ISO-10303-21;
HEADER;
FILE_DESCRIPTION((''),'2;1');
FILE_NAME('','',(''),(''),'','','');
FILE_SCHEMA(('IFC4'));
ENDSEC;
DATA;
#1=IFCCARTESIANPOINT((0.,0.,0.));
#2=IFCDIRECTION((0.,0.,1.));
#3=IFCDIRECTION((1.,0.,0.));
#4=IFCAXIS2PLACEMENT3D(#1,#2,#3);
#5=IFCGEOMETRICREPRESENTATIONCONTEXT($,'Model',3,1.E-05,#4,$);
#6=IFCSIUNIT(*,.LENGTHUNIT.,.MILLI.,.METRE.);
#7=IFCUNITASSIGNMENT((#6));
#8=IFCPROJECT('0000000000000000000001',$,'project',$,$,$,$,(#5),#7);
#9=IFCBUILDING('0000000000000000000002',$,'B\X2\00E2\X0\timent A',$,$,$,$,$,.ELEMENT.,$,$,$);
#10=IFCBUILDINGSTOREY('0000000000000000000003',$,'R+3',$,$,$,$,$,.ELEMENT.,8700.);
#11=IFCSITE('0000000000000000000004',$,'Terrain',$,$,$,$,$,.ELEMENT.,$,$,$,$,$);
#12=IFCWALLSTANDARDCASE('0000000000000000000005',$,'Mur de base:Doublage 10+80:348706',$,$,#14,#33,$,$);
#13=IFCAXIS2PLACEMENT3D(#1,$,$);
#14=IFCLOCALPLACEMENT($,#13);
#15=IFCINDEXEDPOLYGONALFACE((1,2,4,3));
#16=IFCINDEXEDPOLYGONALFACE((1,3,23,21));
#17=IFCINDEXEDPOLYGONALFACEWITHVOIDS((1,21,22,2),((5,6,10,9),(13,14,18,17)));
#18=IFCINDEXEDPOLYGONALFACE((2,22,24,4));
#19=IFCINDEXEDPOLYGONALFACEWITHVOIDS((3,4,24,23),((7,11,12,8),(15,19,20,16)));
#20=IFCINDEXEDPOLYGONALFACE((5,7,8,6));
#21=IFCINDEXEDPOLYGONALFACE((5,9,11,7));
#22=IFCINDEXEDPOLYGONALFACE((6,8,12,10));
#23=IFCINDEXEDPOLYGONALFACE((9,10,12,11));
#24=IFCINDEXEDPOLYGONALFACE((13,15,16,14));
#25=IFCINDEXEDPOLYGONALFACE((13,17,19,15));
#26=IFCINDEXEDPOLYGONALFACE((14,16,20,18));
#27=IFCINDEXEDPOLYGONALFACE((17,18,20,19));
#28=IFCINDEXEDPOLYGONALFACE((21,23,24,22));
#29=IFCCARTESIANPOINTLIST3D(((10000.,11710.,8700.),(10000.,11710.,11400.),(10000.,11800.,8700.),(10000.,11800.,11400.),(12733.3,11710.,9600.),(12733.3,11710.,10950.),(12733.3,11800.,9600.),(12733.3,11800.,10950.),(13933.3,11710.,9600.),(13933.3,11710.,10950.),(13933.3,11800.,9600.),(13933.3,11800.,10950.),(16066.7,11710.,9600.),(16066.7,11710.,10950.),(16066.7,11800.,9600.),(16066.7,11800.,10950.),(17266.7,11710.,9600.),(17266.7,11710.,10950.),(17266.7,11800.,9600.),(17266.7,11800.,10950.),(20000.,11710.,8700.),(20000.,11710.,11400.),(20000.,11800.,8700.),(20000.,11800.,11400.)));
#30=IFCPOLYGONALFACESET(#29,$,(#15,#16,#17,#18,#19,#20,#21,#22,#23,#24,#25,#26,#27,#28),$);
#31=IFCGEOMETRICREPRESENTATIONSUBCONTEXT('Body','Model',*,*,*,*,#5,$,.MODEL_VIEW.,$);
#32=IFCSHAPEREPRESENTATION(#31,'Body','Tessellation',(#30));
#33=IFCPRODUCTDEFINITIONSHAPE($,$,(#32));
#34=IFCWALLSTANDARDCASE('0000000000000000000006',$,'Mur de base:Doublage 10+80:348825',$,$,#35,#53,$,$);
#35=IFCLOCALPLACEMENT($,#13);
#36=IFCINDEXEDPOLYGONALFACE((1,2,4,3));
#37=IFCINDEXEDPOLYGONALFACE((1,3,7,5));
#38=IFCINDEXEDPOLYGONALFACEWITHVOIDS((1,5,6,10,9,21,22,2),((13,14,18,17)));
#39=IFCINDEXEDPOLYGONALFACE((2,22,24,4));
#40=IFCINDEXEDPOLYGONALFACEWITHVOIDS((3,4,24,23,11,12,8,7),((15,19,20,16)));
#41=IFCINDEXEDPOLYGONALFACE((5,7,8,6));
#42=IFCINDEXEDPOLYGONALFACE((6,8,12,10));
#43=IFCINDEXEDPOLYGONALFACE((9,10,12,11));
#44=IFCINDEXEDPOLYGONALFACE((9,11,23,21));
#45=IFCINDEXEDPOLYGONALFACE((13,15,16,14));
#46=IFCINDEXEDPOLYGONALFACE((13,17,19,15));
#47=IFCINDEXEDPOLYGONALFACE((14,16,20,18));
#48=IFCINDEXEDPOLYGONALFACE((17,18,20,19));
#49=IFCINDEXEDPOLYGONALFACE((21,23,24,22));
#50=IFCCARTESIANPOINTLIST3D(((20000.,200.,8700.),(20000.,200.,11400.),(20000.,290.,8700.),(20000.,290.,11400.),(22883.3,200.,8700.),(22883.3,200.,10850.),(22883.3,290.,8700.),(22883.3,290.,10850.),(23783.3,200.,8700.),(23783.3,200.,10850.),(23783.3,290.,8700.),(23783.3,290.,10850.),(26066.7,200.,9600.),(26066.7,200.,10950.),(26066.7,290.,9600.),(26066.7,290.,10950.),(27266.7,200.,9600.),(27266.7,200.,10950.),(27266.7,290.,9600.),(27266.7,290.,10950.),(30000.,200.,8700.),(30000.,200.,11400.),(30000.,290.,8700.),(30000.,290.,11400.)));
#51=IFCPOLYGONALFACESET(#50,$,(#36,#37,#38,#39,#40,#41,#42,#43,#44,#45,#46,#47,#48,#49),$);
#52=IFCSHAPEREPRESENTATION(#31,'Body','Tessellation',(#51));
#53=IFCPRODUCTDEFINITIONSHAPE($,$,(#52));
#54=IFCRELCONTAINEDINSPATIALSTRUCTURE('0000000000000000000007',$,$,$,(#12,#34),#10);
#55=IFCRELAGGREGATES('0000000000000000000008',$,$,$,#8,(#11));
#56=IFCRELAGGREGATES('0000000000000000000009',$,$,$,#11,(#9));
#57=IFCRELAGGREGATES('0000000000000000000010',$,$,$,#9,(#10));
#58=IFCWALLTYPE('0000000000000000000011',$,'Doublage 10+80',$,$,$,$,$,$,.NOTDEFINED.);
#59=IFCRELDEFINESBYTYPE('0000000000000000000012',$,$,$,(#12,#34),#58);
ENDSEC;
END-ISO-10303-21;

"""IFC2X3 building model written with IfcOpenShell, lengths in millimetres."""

from ifc_helpers import new_model, si_unit, frame, frame_2d, origin_with_axes, place, context, subcontext, project, spatial, rectangle, extrude, type_object, element, save


model = new_model("IFC2X3")

# Units and contexts
model_context = context("Model", 3, precision=1e-05, world=origin_with_axes())
body_context = subcontext(model_context, "Body", "Model", "MODEL_VIEW")
ifc_project = project(units=[si_unit("LENGTHUNIT", "METRE", prefix="MILLI")], contexts=[model_context])

# Site, building, storey
site = spatial("IfcSite", under=ifc_project, Name="Terrain", CompositionType="ELEMENT")
building = spatial("IfcBuilding", under=site, Name="Bâtiment A", CompositionType="ELEMENT")
storey = spatial("IfcBuildingStorey", under=building, Name="R+3", CompositionType="ELEMENT", Elevation=8700.0)

# Walls, openings
wall_type_1 = type_object("IfcWallType", Name="Doublage 10+80", PredefinedType="NOTDEFINED")
wall_1_placement = place(None, origin_with_axes())
wall_1 = element("IfcWallStandardCase", 1, at=wall_1_placement, inside=storey, type_object=wall_type_1, Name="Mur de base:Doublage 10+80:348706", context=body_context, shape_type="SweptSolid", body=[
    extrude(rectangle(XDim=10000.0, YDim=90.0, at=frame_2d((15000.0, 11755.0))), frame((0.0, 0.0, 8700.0), z_axis=(0.0, 0.0, 1.0), x_axis=(1.0, 0.0, 0.0)), (0.0, 0.0, 1.0), 2700.0),
])
opening_1_placement = place(None, origin_with_axes())
element("IfcOpeningElement", 2, at=opening_1_placement, cuts=wall_1, context=body_context, shape_type="SweptSolid", body=[
    extrude(rectangle(XDim=1200.0, YDim=210.0, at=frame_2d((13333.3, 11755.0))), frame((0.0, 0.0, 9600.0), z_axis=(0.0, 0.0, 1.0), x_axis=(1.0, 0.0, 0.0)), (0.0, 0.0, 1.0), 1350.0),
])
opening_2_placement = place(None, origin_with_axes())
element("IfcOpeningElement", 3, at=opening_2_placement, cuts=wall_1, context=body_context, shape_type="SweptSolid", body=[
    extrude(rectangle(XDim=1200.0, YDim=210.0, at=frame_2d((16666.7, 11755.0))), frame((0.0, 0.0, 9600.0), z_axis=(0.0, 0.0, 1.0), x_axis=(1.0, 0.0, 0.0)), (0.0, 0.0, 1.0), 1350.0),
])
wall_2_placement = place(None, origin_with_axes())
wall_2 = element("IfcWallStandardCase", 4, at=wall_2_placement, inside=storey, type_object=wall_type_1, Name="Mur de base:Doublage 10+80:348825", context=body_context, shape_type="SweptSolid", body=[
    extrude(rectangle(XDim=10000.0, YDim=90.0, at=frame_2d((25000.0, 245.0))), frame((0.0, 0.0, 8700.0), z_axis=(0.0, 0.0, 1.0), x_axis=(1.0, 0.0, 0.0)), (0.0, 0.0, 1.0), 2700.0),
])
opening_3_placement = place(None, origin_with_axes())
element("IfcOpeningElement", 5, at=opening_3_placement, cuts=wall_2, context=body_context, shape_type="SweptSolid", body=[
    extrude(rectangle(XDim=900.0, YDim=210.0, at=frame_2d((23333.3, 245.0))), frame((0.0, 0.0, 8700.0), z_axis=(0.0, 0.0, 1.0), x_axis=(1.0, 0.0, 0.0)), (0.0, 0.0, 1.0), 2150.0),
])
opening_4_placement = place(None, origin_with_axes())
element("IfcOpeningElement", 6, at=opening_4_placement, cuts=wall_2, context=body_context, shape_type="SweptSolid", body=[
    extrude(rectangle(XDim=1200.0, YDim=210.0, at=frame_2d((26666.7, 245.0))), frame((0.0, 0.0, 9600.0), z_axis=(0.0, 0.0, 1.0), x_axis=(1.0, 0.0, 0.0)), (0.0, 0.0, 1.0), 1350.0),
])

save(model, "model.ifc")
